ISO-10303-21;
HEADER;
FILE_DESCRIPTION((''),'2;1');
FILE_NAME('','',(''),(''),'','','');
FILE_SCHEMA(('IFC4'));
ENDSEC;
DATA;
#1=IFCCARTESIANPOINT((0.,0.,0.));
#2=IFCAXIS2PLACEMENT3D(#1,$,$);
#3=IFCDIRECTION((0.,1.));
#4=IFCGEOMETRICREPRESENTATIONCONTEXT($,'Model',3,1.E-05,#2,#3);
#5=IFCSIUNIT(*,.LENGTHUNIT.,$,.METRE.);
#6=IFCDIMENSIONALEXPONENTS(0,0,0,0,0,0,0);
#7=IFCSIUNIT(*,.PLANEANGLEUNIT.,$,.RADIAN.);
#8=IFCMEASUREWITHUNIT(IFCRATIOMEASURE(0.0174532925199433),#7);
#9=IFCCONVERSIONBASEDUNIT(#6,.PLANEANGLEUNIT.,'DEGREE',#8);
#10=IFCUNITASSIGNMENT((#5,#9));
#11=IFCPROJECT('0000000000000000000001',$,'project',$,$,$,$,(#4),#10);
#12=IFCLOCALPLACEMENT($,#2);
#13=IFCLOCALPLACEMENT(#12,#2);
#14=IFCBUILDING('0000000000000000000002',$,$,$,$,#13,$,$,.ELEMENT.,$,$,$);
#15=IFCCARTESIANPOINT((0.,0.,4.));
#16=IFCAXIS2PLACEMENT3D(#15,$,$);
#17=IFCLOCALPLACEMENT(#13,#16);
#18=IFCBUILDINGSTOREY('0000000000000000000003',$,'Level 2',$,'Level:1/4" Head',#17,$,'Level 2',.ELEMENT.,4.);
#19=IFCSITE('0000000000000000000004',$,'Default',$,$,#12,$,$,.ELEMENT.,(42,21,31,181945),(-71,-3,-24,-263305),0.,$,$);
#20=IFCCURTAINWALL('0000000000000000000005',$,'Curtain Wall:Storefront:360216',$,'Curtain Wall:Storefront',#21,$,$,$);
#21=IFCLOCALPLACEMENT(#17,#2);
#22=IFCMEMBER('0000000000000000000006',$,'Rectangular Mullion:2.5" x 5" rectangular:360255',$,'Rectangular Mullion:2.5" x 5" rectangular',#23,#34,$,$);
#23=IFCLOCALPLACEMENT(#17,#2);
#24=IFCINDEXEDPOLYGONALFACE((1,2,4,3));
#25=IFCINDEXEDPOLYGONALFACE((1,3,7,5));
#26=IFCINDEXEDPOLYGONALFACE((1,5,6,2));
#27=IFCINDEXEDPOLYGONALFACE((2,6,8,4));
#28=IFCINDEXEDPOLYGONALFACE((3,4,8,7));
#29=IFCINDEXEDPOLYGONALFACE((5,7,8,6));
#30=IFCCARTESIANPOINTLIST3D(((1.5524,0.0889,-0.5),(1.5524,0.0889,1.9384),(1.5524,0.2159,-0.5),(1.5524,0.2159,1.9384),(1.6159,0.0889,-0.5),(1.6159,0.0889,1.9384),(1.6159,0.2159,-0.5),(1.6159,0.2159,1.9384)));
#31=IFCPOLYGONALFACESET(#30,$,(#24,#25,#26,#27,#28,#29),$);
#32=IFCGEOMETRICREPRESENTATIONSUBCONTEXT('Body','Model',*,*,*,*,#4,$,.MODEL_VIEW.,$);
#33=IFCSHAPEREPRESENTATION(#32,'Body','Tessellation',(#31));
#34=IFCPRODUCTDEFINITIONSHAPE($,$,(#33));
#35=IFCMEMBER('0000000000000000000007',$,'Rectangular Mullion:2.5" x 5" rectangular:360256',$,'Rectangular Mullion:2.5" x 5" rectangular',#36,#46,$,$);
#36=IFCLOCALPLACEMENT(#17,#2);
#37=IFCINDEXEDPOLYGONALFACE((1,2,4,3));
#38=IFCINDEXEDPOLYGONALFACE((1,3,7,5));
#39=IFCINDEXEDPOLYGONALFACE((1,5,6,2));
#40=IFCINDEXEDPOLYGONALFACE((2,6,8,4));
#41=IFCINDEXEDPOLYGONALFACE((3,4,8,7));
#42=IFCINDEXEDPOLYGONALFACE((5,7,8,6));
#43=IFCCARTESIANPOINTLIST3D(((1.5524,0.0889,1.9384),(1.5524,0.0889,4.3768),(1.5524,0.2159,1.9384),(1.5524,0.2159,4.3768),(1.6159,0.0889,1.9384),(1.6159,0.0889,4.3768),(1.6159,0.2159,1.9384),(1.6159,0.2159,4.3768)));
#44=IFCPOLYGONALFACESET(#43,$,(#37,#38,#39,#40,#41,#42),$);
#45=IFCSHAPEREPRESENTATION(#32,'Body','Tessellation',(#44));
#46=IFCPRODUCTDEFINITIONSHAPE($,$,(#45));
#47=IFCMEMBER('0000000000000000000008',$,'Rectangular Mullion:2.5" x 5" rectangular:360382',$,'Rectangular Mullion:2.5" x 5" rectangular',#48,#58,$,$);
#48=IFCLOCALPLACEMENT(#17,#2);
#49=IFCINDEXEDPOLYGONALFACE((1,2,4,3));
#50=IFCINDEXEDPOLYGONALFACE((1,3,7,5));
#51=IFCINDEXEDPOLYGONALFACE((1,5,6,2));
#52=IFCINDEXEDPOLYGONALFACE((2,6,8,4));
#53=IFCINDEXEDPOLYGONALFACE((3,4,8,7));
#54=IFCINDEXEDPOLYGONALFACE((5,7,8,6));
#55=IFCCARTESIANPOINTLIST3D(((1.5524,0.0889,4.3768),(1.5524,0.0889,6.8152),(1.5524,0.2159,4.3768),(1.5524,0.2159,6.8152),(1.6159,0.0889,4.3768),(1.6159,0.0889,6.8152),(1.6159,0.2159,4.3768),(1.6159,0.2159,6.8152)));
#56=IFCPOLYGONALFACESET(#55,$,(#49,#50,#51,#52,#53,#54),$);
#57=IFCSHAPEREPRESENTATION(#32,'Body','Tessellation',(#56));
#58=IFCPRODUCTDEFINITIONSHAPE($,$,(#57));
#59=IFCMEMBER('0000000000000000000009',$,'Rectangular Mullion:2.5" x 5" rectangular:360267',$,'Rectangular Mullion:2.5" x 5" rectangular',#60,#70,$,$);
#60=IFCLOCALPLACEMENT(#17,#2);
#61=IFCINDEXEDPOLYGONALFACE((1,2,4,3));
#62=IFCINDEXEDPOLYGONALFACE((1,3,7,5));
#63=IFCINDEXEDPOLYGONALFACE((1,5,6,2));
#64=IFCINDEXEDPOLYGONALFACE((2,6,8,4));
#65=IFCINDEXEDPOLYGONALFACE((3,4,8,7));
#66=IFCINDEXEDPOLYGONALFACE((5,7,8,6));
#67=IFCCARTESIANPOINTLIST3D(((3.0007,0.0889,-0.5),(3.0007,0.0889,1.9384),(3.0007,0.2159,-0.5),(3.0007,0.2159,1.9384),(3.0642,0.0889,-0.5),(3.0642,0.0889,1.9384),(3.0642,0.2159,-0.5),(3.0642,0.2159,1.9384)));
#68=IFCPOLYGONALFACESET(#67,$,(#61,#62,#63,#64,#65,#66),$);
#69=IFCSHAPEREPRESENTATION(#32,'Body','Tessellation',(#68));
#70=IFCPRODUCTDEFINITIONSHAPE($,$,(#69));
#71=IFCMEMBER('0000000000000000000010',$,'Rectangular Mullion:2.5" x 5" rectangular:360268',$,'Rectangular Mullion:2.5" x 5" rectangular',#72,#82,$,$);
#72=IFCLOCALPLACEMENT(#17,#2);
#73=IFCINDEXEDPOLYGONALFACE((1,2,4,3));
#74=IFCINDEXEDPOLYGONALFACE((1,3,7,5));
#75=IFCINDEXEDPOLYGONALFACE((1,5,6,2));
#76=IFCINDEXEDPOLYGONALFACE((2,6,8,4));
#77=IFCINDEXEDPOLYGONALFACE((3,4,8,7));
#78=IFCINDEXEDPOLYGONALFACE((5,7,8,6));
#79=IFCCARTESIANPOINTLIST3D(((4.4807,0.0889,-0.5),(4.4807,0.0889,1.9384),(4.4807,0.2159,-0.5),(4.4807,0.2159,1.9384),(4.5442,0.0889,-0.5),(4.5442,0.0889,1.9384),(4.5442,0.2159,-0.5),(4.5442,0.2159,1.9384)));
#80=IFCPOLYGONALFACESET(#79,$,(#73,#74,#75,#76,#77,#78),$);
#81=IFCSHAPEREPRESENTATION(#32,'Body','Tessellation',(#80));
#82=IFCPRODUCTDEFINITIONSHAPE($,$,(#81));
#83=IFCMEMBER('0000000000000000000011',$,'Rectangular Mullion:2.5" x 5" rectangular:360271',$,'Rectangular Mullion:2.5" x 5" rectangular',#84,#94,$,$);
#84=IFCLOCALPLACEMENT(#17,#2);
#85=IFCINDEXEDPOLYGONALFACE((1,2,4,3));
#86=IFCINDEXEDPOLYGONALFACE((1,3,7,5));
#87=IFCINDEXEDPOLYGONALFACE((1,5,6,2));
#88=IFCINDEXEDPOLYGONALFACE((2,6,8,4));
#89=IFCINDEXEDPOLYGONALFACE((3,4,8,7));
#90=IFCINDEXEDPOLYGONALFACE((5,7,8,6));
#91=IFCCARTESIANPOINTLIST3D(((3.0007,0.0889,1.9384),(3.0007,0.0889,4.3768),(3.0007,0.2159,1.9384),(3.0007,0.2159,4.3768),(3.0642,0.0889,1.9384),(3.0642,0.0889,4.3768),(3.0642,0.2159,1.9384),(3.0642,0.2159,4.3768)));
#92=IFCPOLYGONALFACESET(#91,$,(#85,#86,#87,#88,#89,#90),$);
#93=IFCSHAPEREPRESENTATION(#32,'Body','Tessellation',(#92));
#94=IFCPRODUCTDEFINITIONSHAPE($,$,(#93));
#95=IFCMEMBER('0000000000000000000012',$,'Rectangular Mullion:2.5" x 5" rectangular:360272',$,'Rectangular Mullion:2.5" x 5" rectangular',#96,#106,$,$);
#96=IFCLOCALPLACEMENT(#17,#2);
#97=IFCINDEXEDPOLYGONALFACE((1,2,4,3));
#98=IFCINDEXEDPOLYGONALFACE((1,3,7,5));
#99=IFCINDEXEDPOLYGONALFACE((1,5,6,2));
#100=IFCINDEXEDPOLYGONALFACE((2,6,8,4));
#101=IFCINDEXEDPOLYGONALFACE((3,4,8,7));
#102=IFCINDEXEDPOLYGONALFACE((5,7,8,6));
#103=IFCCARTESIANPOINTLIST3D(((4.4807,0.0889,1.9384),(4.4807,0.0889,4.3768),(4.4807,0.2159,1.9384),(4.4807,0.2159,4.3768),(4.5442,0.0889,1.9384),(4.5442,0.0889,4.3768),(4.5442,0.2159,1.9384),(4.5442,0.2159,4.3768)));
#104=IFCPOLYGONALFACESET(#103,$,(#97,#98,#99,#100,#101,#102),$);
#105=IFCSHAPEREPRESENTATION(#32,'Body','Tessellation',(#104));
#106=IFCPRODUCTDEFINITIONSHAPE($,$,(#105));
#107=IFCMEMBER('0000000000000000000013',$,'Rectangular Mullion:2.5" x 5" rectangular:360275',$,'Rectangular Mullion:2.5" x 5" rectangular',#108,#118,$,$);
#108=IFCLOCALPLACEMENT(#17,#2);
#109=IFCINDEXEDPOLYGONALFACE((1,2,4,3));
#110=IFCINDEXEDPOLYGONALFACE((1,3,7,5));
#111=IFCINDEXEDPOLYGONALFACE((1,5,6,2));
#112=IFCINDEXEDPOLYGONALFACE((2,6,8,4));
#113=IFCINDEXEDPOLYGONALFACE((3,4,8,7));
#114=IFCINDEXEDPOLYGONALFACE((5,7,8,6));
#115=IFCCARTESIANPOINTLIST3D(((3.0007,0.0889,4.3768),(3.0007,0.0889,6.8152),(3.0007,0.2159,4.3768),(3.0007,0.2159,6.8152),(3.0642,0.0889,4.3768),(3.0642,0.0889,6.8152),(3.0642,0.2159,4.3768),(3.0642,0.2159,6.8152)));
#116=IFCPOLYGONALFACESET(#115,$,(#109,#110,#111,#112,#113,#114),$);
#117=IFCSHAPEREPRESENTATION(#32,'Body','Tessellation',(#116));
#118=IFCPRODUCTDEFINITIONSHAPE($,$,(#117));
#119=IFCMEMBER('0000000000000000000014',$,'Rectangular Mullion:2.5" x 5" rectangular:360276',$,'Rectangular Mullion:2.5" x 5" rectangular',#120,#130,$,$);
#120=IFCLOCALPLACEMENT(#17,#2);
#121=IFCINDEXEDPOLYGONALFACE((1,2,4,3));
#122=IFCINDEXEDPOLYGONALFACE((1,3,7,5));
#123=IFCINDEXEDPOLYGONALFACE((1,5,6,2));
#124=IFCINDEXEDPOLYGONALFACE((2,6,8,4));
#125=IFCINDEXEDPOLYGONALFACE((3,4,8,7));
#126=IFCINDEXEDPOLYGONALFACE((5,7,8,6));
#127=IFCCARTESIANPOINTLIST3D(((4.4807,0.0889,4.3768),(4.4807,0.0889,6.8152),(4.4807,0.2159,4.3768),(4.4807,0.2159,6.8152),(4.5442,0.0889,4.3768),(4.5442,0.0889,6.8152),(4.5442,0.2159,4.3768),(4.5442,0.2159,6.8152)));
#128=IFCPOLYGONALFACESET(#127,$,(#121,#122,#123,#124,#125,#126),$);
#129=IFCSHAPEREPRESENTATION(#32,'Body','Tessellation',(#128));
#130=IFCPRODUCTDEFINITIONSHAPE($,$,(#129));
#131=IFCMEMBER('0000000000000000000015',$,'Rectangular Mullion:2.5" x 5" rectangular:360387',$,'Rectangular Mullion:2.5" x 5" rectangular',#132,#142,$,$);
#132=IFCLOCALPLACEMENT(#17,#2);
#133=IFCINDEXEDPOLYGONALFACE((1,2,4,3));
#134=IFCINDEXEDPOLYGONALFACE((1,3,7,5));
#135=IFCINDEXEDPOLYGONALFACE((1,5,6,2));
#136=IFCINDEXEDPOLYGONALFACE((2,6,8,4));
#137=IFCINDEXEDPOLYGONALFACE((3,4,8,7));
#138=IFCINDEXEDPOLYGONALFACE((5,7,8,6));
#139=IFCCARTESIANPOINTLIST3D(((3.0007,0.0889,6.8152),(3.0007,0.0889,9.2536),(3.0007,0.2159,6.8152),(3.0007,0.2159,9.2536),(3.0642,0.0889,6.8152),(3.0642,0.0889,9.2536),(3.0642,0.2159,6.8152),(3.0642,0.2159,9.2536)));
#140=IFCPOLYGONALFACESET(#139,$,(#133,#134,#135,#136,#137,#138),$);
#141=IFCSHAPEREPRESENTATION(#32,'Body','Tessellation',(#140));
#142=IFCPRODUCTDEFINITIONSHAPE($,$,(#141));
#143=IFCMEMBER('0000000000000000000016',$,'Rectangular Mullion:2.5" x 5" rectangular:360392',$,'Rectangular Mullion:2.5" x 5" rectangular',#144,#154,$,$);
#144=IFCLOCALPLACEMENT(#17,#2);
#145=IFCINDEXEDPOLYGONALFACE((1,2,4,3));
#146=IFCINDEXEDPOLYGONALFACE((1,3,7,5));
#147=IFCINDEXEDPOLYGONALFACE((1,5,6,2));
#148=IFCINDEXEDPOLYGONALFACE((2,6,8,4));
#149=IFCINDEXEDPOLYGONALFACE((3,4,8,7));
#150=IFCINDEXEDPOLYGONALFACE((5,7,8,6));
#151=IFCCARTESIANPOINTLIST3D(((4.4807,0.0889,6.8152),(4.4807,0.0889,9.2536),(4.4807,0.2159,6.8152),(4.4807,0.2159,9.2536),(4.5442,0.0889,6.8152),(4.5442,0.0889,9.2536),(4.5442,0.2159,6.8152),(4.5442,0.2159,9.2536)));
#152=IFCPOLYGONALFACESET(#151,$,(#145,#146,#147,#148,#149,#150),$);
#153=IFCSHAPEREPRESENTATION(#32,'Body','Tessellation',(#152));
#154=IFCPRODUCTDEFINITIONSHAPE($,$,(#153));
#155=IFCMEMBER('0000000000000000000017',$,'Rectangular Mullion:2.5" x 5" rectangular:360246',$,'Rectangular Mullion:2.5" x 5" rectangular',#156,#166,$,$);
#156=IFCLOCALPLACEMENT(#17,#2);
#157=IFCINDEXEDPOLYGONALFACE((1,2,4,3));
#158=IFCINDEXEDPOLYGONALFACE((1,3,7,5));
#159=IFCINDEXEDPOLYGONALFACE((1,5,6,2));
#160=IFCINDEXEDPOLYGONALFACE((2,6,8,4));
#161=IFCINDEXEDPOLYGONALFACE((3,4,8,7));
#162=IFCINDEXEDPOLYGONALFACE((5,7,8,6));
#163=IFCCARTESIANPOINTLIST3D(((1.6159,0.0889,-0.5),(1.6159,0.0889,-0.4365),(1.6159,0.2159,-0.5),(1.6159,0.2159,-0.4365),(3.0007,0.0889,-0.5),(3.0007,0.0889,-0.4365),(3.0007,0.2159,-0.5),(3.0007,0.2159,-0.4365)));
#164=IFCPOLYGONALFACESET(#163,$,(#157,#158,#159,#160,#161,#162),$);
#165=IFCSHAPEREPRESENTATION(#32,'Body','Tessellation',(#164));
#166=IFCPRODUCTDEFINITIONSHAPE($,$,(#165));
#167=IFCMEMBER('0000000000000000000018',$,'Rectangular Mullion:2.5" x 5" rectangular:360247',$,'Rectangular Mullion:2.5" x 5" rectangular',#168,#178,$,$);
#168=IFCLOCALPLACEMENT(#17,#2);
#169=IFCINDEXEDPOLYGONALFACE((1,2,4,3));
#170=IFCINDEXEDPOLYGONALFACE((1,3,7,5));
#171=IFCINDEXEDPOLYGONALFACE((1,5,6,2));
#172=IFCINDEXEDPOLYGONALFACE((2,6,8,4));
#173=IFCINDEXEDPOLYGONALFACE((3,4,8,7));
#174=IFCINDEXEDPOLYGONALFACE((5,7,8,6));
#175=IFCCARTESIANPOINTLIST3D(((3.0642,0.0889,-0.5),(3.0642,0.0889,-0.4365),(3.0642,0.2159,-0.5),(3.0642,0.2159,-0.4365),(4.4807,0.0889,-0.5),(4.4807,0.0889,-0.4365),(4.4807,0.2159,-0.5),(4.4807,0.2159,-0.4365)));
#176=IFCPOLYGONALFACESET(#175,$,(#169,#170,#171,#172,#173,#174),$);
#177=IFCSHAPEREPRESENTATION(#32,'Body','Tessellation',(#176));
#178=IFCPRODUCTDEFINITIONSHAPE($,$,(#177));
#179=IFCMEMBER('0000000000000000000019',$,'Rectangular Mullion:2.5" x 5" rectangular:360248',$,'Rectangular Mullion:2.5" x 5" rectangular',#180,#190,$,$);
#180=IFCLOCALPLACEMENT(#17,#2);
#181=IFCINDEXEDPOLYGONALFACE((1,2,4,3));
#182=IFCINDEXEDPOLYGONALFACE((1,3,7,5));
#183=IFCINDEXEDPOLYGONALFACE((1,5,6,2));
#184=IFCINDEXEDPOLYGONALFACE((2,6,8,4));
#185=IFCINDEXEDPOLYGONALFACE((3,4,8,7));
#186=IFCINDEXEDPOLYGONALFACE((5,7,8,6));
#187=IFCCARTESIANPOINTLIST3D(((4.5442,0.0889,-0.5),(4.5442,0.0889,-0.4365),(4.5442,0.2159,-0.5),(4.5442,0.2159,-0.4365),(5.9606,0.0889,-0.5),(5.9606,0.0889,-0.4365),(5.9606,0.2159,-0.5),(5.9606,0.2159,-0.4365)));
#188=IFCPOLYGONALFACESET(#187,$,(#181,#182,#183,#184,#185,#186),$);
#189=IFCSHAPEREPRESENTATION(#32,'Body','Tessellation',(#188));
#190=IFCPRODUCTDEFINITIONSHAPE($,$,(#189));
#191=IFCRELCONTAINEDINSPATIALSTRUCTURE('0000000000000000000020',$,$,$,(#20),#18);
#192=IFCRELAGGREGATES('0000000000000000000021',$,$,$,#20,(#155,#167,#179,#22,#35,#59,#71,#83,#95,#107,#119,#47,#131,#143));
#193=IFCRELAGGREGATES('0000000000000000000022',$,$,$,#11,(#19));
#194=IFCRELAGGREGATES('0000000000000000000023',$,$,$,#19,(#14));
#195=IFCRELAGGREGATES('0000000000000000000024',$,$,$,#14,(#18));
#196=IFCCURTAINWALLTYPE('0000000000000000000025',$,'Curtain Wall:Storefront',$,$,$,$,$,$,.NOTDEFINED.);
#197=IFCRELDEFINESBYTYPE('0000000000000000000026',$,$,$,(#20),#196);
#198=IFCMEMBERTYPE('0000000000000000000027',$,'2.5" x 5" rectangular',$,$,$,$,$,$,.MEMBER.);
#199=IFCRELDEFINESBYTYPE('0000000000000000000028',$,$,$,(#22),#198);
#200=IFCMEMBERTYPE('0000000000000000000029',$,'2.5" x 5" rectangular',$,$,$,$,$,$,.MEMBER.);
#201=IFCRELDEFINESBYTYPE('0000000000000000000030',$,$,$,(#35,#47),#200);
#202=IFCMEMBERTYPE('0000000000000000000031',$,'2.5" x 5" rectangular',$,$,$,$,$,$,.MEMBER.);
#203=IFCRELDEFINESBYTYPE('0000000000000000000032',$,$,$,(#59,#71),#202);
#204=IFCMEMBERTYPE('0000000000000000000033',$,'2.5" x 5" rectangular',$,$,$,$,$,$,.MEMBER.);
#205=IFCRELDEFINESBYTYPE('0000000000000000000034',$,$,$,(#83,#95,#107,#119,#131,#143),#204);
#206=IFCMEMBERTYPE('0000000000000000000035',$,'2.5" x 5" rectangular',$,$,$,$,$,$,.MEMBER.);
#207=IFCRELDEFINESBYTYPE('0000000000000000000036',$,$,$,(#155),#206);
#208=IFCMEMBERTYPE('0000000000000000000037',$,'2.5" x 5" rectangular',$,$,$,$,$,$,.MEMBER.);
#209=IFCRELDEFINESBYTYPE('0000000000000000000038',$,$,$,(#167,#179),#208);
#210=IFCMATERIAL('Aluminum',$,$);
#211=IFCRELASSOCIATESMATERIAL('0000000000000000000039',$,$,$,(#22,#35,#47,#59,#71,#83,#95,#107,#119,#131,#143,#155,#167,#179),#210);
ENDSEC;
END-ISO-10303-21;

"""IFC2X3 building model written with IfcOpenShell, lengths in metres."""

from ifc_helpers import new_model, entity, si_unit, converted_unit, direction, frame, origin, origin_2d_with_axis, place, context, subcontext, project, spatial, rectangle, extrude, source, transform, mapped, material, type_object, type_shapes, element, aggregate, save


model = new_model("IFC2X3")

# Units and contexts
model_context = context("Model", 3, precision=1e-05, world=origin(), true_north=direction((0.0, 1.0)))
body_context = subcontext(model_context, "Body", "Model", "MODEL_VIEW")
ifc_project = project(units=[si_unit("LENGTHUNIT", "METRE"), converted_unit("PLANEANGLEUNIT", "DEGREE", entity("IfcRatioMeasure", 0.0174532925199433), si_unit("PLANEANGLEUNIT", "RADIAN"), dimensions=[0, 0, 0, 0, 0, 0, 0])], contexts=[model_context])

# Site, building, storey
site_placement = place(None, origin())
site = spatial("IfcSite", under=ifc_project, at=site_placement, Name="Default", CompositionType="ELEMENT", RefLatitude=(42, 21, 31, 181945), RefLongitude=(-71, -3, -24, -263305), RefElevation=0.0)
building_placement = place(site_placement, origin())
building = spatial("IfcBuilding", under=site, at=building_placement, CompositionType="ELEMENT")
storey_placement = place(building_placement, frame((0.0, 0.0, 4.0)))
storey = spatial("IfcBuildingStorey", under=building, at=storey_placement, Name="Level 2", ObjectType="Level:1/4\" Head", LongName="Level 2", CompositionType="ELEMENT", Elevation=4.0)

# Curtain wall, members
curtain_wall_type = type_object("IfcCurtainWallType", Name="Curtain Wall:Storefront", PredefinedType="NOTDEFINED")
curtain_wall_placement = place(storey_placement, frame((0.0, 0.0, -4.0)))
curtain_wall = element("IfcCurtainWall", 1, at=curtain_wall_placement, inside=storey, type_object=curtain_wall_type, Name="Curtain Wall:Storefront:360216", ObjectType="Curtain Wall:Storefront")
ifc_material_1 = material(Name="Aluminum")
member_type_1 = type_object("IfcMemberType", Name="2.5\" x 5\" rectangular", PredefinedType="MEMBER")
shared_shape_1 = source(origin(), body_context, "Body", "SweptSolid", [
    extrude(rectangle(XDim=0.127, YDim=0.0635, at=origin_2d_with_axis()), frame((-0.0318, 0.0, -2.4384), z_axis=(0.0, 0.0, 1.0), x_axis=(0.0, -1.0, 0.0)), (0.0, 0.0, 1.0), 2.4384),
])
type_shapes(member_type_1, [shared_shape_1])
member_1_placement = place(storey_placement, frame((1.5524, 0.1524, 1.9384), z_axis=(0.0, 0.0, 1.0), x_axis=(-1.0, 0.0, 0.0)))
member_1 = element("IfcMember", 2, at=member_1_placement, type_object=member_type_1, material=ifc_material_1, Name="Rectangular Mullion:2.5\" x 5\" rectangular:360255", ObjectType="Rectangular Mullion:2.5\" x 5\" rectangular", context=body_context, shape_type="MappedRepresentation", body=[
    mapped(shared_shape_1, transform((0.0, 0.0, 0.0), scale=1.0)),
])
member_type_2 = type_object("IfcMemberType", Name="2.5\" x 5\" rectangular", PredefinedType="MEMBER")
shared_shape_2 = source(origin(), body_context, "Body", "SweptSolid", [
    extrude(rectangle(XDim=0.127, YDim=0.0635, at=origin_2d_with_axis()), frame((-0.0318, 0.0, -2.4384), z_axis=(0.0, 0.0, 1.0), x_axis=(0.0, -1.0, 0.0)), (0.0, 0.0, 1.0), 2.4384),
])
type_shapes(member_type_2, [shared_shape_2])
member_2_placement = place(storey_placement, frame((1.5524, 0.1524, 4.3768), z_axis=(0.0, 0.0, 1.0), x_axis=(-1.0, 0.0, 0.0)))
member_2 = element("IfcMember", 3, at=member_2_placement, type_object=member_type_2, material=ifc_material_1, Name="Rectangular Mullion:2.5\" x 5\" rectangular:360256", ObjectType="Rectangular Mullion:2.5\" x 5\" rectangular", context=body_context, shape_type="MappedRepresentation", body=[
    mapped(shared_shape_2, transform((0.0, 0.0, 0.0), scale=1.0)),
])
member_3_placement = place(storey_placement, frame((1.5524, 0.1524, 6.8152), z_axis=(0.0, 0.0, 1.0), x_axis=(-1.0, 0.0, 0.0)))
member_3 = element("IfcMember", 4, at=member_3_placement, type_object=member_type_2, material=ifc_material_1, Name="Rectangular Mullion:2.5\" x 5\" rectangular:360382", ObjectType="Rectangular Mullion:2.5\" x 5\" rectangular", context=body_context, shape_type="MappedRepresentation", body=[
    mapped(shared_shape_2, transform((0.0, 0.0, 0.0), scale=1.0)),
])
member_type_3 = type_object("IfcMemberType", Name="2.5\" x 5\" rectangular", PredefinedType="MEMBER")
shared_shape_3 = source(origin(), body_context, "Body", "SweptSolid", [
    extrude(rectangle(XDim=0.127, YDim=0.0635, at=origin_2d_with_axis()), frame((0.0, 0.0, -2.4384), z_axis=(0.0, 0.0, 1.0), x_axis=(0.0, -1.0, 0.0)), (0.0, 0.0, 1.0), 2.4384),
])
type_shapes(member_type_3, [shared_shape_3])
member_4_placement = place(storey_placement, frame((3.0324, 0.1524, -0.5), z_axis=(0.0, 0.0, -1.0), x_axis=(1.0, 0.0, 0.0)))
member_4 = element("IfcMember", 5, at=member_4_placement, type_object=member_type_3, material=ifc_material_1, Name="Rectangular Mullion:2.5\" x 5\" rectangular:360267", ObjectType="Rectangular Mullion:2.5\" x 5\" rectangular", context=body_context, shape_type="MappedRepresentation", body=[
    mapped(shared_shape_3, transform((0.0, 0.0, 0.0), scale=1.0)),
])
member_5_placement = place(storey_placement, frame((4.5124, 0.1524, -0.5), z_axis=(0.0, 0.0, -1.0), x_axis=(1.0, 0.0, 0.0)))
member_5 = element("IfcMember", 6, at=member_5_placement, type_object=member_type_3, material=ifc_material_1, Name="Rectangular Mullion:2.5\" x 5\" rectangular:360268", ObjectType="Rectangular Mullion:2.5\" x 5\" rectangular", context=body_context, shape_type="MappedRepresentation", body=[
    mapped(shared_shape_3, transform((0.0, 0.0, 0.0), scale=1.0)),
])
member_type_4 = type_object("IfcMemberType", Name="2.5\" x 5\" rectangular", PredefinedType="MEMBER")
shared_shape_4 = source(origin(), body_context, "Body", "SweptSolid", [
    extrude(rectangle(XDim=0.127, YDim=0.0635, at=origin_2d_with_axis()), frame((0.0, 0.0, -2.4384), z_axis=(0.0, 0.0, 1.0), x_axis=(0.0, -1.0, 0.0)), (0.0, 0.0, 1.0), 2.4384),
])
type_shapes(member_type_4, [shared_shape_4])
member_6_placement = place(storey_placement, frame((3.0324, 0.1524, 1.9384), z_axis=(0.0, 0.0, -1.0), x_axis=(1.0, 0.0, 0.0)))
member_6 = element("IfcMember", 7, at=member_6_placement, type_object=member_type_4, material=ifc_material_1, Name="Rectangular Mullion:2.5\" x 5\" rectangular:360271", ObjectType="Rectangular Mullion:2.5\" x 5\" rectangular", context=body_context, shape_type="MappedRepresentation", body=[
    mapped(shared_shape_4, transform((0.0, 0.0, 0.0), scale=1.0)),
])
member_7_placement = place(storey_placement, frame((4.5124, 0.1524, 1.9384), z_axis=(0.0, 0.0, -1.0), x_axis=(1.0, 0.0, 0.0)))
member_7 = element("IfcMember", 8, at=member_7_placement, type_object=member_type_4, material=ifc_material_1, Name="Rectangular Mullion:2.5\" x 5\" rectangular:360272", ObjectType="Rectangular Mullion:2.5\" x 5\" rectangular", context=body_context, shape_type="MappedRepresentation", body=[
    mapped(shared_shape_4, transform((0.0, 0.0, 0.0), scale=1.0)),
])
member_8_placement = place(storey_placement, frame((3.0324, 0.1524, 4.3768), z_axis=(0.0, 0.0, -1.0), x_axis=(1.0, 0.0, 0.0)))
member_8 = element("IfcMember", 9, at=member_8_placement, type_object=member_type_4, material=ifc_material_1, Name="Rectangular Mullion:2.5\" x 5\" rectangular:360275", ObjectType="Rectangular Mullion:2.5\" x 5\" rectangular", context=body_context, shape_type="MappedRepresentation", body=[
    mapped(shared_shape_4, transform((0.0, 0.0, 0.0), scale=1.0)),
])
member_9_placement = place(storey_placement, frame((4.5124, 0.1524, 4.3768), z_axis=(0.0, 0.0, -1.0), x_axis=(1.0, 0.0, 0.0)))
member_9 = element("IfcMember", 10, at=member_9_placement, type_object=member_type_4, material=ifc_material_1, Name="Rectangular Mullion:2.5\" x 5\" rectangular:360276", ObjectType="Rectangular Mullion:2.5\" x 5\" rectangular", context=body_context, shape_type="MappedRepresentation", body=[
    mapped(shared_shape_4, transform((0.0, 0.0, 0.0), scale=1.0)),
])
member_10_placement = place(storey_placement, frame((3.0324, 0.1524, 6.8152), z_axis=(0.0, 0.0, -1.0), x_axis=(1.0, 0.0, 0.0)))
member_10 = element("IfcMember", 11, at=member_10_placement, type_object=member_type_4, material=ifc_material_1, Name="Rectangular Mullion:2.5\" x 5\" rectangular:360387", ObjectType="Rectangular Mullion:2.5\" x 5\" rectangular", context=body_context, shape_type="MappedRepresentation", body=[
    mapped(shared_shape_4, transform((0.0, 0.0, 0.0), scale=1.0)),
])
member_11_placement = place(storey_placement, frame((4.5124, 0.1524, 6.8152), z_axis=(0.0, 0.0, -1.0), x_axis=(1.0, 0.0, 0.0)))
member_11 = element("IfcMember", 12, at=member_11_placement, type_object=member_type_4, material=ifc_material_1, Name="Rectangular Mullion:2.5\" x 5\" rectangular:360392", ObjectType="Rectangular Mullion:2.5\" x 5\" rectangular", context=body_context, shape_type="MappedRepresentation", body=[
    mapped(shared_shape_4, transform((0.0, 0.0, 0.0), scale=1.0)),
])
member_type_5 = type_object("IfcMemberType", Name="2.5\" x 5\" rectangular", PredefinedType="MEMBER")
shared_shape_5 = source(origin(), body_context, "Body", "SweptSolid", [
    extrude(rectangle(XDim=0.127, YDim=0.0635, at=origin_2d_with_axis()), frame((-0.0318, 0.0, -1.3848), z_axis=(0.0, 0.0, 1.0), x_axis=(0.0, -1.0, 0.0)), (0.0, 0.0, 1.0), 1.3848),
])
type_shapes(member_type_5, [shared_shape_5])
member_12_placement = place(storey_placement, frame((1.6159, 0.1524, -0.5), z_axis=(-1.0, 0.0, 0.0), x_axis=(0.0, 0.0, -1.0)))
member_12 = element("IfcMember", 13, at=member_12_placement, type_object=member_type_5, material=ifc_material_1, Name="Rectangular Mullion:2.5\" x 5\" rectangular:360246", ObjectType="Rectangular Mullion:2.5\" x 5\" rectangular", context=body_context, shape_type="MappedRepresentation", body=[
    mapped(shared_shape_5, transform((0.0, 0.0, 0.0), scale=1.0)),
])
member_type_6 = type_object("IfcMemberType", Name="2.5\" x 5\" rectangular", PredefinedType="MEMBER")
shared_shape_6 = source(origin(), body_context, "Body", "SweptSolid", [
    extrude(rectangle(XDim=0.127, YDim=0.0635, at=origin_2d_with_axis()), frame((-0.0318, 0.0, -1.4165), z_axis=(0.0, 0.0, 1.0), x_axis=(0.0, -1.0, 0.0)), (0.0, 0.0, 1.0), 1.4165),
])
type_shapes(member_type_6, [shared_shape_6])
member_13_placement = place(storey_placement, frame((3.0642, 0.1524, -0.5), z_axis=(-1.0, 0.0, 0.0), x_axis=(0.0, 0.0, -1.0)))
member_13 = element("IfcMember", 14, at=member_13_placement, type_object=member_type_6, material=ifc_material_1, Name="Rectangular Mullion:2.5\" x 5\" rectangular:360247", ObjectType="Rectangular Mullion:2.5\" x 5\" rectangular", context=body_context, shape_type="MappedRepresentation", body=[
    mapped(shared_shape_6, transform((0.0, 0.0, 0.0), scale=1.0)),
])
member_14_placement = place(storey_placement, frame((4.5442, 0.1524, -0.5), z_axis=(-1.0, 0.0, 0.0), x_axis=(0.0, 0.0, -1.0)))
member_14 = element("IfcMember", 15, at=member_14_placement, type_object=member_type_6, material=ifc_material_1, Name="Rectangular Mullion:2.5\" x 5\" rectangular:360248", ObjectType="Rectangular Mullion:2.5\" x 5\" rectangular", context=body_context, shape_type="MappedRepresentation", body=[
    mapped(shared_shape_6, transform((0.0, 0.0, 0.0), scale=1.0)),
])

aggregate(curtain_wall, [member_12, member_13, member_14, member_1, member_2, member_4, member_5, member_6, member_7, member_8, member_9, member_3, member_10, member_11])

save(model, "model.ifc")
